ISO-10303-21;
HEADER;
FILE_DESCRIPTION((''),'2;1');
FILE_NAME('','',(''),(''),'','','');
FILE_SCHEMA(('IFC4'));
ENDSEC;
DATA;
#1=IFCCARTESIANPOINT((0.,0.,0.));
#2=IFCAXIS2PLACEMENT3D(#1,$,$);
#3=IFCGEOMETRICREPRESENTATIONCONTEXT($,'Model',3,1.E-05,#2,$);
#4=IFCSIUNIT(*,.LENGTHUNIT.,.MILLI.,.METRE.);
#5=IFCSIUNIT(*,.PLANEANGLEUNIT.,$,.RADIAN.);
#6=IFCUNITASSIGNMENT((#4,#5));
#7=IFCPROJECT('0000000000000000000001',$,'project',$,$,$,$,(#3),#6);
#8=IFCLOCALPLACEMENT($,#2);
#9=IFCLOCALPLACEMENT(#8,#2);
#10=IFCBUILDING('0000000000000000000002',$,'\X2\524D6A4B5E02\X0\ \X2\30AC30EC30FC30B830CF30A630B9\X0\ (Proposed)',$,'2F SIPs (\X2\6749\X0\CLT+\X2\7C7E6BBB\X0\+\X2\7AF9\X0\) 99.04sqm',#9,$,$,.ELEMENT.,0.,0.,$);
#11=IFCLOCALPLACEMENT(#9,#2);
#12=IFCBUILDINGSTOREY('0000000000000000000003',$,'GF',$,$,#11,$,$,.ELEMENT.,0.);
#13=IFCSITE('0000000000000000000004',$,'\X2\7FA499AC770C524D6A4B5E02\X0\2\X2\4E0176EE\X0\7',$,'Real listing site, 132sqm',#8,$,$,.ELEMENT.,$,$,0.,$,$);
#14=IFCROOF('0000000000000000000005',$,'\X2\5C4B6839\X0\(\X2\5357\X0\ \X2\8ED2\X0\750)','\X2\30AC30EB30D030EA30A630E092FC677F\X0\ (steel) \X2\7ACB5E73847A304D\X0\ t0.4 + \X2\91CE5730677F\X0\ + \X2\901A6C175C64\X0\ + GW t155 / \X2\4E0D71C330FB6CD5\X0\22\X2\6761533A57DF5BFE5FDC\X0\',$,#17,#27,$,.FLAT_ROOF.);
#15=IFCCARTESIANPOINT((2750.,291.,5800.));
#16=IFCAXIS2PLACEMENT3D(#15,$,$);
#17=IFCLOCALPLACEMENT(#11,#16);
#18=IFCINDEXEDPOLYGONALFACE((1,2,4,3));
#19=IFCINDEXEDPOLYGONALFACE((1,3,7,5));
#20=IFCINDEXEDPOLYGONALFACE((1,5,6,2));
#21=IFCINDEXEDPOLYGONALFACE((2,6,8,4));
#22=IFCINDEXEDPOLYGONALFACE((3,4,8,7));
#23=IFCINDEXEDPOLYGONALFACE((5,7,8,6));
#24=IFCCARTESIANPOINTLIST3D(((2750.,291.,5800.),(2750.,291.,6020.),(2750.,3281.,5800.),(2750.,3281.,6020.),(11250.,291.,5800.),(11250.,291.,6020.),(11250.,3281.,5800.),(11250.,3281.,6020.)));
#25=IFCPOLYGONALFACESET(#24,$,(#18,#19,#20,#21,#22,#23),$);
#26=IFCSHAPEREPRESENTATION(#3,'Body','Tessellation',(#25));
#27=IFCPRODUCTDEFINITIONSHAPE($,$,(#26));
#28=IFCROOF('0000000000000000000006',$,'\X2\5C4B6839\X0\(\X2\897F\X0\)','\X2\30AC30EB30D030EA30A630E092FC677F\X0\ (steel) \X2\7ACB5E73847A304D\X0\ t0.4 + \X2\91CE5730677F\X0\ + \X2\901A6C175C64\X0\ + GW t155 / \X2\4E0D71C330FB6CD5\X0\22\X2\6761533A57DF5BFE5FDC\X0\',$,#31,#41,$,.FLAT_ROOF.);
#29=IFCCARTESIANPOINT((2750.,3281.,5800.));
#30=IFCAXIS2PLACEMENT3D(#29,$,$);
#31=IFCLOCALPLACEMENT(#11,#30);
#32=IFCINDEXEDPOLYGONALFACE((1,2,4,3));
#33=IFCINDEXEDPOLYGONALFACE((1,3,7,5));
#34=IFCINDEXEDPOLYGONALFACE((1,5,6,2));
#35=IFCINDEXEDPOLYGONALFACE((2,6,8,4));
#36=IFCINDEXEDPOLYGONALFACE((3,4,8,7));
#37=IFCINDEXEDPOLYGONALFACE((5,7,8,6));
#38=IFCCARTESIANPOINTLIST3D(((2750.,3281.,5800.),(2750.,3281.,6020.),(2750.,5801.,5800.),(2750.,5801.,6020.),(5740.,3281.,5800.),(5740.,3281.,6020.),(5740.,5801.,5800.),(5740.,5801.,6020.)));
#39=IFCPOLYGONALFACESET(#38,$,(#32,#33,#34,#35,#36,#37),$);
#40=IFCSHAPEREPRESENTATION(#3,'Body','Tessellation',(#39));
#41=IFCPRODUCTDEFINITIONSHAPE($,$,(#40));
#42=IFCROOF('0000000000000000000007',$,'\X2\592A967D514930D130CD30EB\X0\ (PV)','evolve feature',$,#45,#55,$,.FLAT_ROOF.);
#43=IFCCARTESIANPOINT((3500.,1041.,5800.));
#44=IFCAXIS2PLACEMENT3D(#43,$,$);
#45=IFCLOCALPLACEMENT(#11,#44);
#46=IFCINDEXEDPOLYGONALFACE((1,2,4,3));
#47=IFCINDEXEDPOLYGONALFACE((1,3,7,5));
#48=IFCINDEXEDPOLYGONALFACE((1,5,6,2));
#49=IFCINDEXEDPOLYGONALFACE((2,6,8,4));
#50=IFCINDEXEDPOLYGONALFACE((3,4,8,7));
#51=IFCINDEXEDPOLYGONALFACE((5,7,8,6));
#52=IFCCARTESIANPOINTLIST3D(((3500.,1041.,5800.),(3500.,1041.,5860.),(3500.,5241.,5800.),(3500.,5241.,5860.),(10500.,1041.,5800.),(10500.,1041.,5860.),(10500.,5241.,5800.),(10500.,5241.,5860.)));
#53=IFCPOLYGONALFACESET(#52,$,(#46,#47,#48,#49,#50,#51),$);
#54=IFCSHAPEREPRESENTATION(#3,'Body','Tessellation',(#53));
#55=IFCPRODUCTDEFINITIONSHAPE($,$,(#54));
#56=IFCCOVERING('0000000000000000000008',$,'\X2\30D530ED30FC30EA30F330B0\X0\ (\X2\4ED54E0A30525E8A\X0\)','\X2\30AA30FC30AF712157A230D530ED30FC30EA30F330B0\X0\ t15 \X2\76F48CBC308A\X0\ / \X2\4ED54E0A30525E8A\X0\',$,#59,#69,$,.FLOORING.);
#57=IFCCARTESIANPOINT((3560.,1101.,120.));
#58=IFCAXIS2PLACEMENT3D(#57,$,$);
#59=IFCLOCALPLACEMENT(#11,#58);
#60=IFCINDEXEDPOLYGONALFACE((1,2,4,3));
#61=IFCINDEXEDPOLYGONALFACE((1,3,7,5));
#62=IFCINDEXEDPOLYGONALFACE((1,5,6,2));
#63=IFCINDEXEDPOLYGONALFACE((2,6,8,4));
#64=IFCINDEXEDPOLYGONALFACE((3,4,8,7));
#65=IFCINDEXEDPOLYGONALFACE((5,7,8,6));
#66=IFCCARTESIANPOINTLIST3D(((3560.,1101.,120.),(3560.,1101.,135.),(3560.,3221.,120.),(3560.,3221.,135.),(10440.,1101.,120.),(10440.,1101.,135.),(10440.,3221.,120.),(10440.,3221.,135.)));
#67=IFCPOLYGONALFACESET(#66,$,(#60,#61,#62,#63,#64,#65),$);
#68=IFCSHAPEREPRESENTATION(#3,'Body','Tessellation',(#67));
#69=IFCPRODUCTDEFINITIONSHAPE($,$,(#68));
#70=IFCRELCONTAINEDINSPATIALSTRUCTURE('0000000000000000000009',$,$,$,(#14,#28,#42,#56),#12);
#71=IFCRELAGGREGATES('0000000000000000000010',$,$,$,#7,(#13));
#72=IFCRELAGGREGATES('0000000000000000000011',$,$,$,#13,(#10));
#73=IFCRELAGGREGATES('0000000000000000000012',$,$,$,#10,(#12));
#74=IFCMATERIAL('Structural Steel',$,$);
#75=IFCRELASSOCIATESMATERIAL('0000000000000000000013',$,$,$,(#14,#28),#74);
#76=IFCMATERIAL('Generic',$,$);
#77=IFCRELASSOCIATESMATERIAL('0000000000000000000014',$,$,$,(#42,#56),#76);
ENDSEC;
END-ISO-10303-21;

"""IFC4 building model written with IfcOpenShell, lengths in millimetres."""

from ifc_helpers import new_model, si_unit, frame, frame_2d, origin, place, context, project, spatial, rectangle, extrude, material, element, save


model = new_model("IFC4")

# Units and contexts
model_context = context("Model", 3, precision=1e-05, world=origin())
ifc_project = project(units=[si_unit("LENGTHUNIT", "METRE", prefix="MILLI"), si_unit("PLANEANGLEUNIT", "RADIAN")], contexts=[model_context])

# Site, building, storey
site_placement = place(None, origin())
site = spatial("IfcSite", under=ifc_project, at=site_placement, Name="群馬県前橋市2丁目7", ObjectType="Real listing site, 132sqm", CompositionType="ELEMENT", RefElevation=0.0)
building_placement = place(site_placement, origin())
building = spatial("IfcBuilding", under=site, at=building_placement, Name="前橋市 ガレージハウス (Proposed)", ObjectType="2F SIPs (杉CLT+籾殻+竹) 99.04sqm", CompositionType="ELEMENT", ElevationOfRefHeight=0.0, ElevationOfTerrain=0.0)
storey_placement = place(building_placement, origin())
storey = spatial("IfcBuildingStorey", under=building, at=storey_placement, Name="GF", CompositionType="ELEMENT", Elevation=0.0)

# Shared definitions
ifc_material_1 = material(Name="Generic")

# Roofs
ifc_material_2 = material(Name="Structural Steel")
roof_1_placement = place(storey_placement, frame((2750.0, 291.0, 5800.0)))
element("IfcRoof", 1, at=roof_1_placement, inside=storey, material=ifc_material_2, Name="屋根(南 軒750)", Description="ガルバリウム鋼板 (steel) 立平葺き t0.4 + 野地板 + 通気層 + GW t155 / 不燃・法22条区域対応", PredefinedType="FLAT_ROOF", context=model_context, shape_type="SweptSolid", body=[
    extrude(rectangle(XDim=8500.0, YDim=2990.0, at=frame_2d((4250.0, 1495.0))), frame((2750.0, 291.0, 5800.0)), (0.0, 0.0, 1.0), 220.0),
])
roof_2_placement = place(storey_placement, frame((2750.0, 3281.0, 5800.0)))
element("IfcRoof", 2, at=roof_2_placement, inside=storey, material=ifc_material_2, Name="屋根(西)", Description="ガルバリウム鋼板 (steel) 立平葺き t0.4 + 野地板 + 通気層 + GW t155 / 不燃・法22条区域対応", PredefinedType="FLAT_ROOF", context=model_context, shape_type="SweptSolid", body=[
    extrude(rectangle(XDim=2990.0, YDim=2520.0, at=frame_2d((1495.0, 1260.0))), frame((2750.0, 3281.0, 5800.0)), (0.0, 0.0, 1.0), 220.0),
])
roof_3_placement = place(storey_placement, frame((3500.0, 1041.0, 5800.0)))
element("IfcRoof", 3, at=roof_3_placement, inside=storey, material=ifc_material_1, Name="太陽光パネル (PV)", Description="evolve feature", PredefinedType="FLAT_ROOF", context=model_context, shape_type="SweptSolid", body=[
    extrude(rectangle(XDim=7000.0, YDim=4200.0, at=frame_2d((3500.0, 2100.0))), frame((3500.0, 1041.0, 5800.0)), (0.0, 0.0, 1.0), 60.0),
])

# Covering
covering_placement = place(storey_placement, frame((3560.0, 1101.0, 120.0)))
element("IfcCovering", 4, at=covering_placement, inside=storey, material=ifc_material_1, Name="フローリング (仕上げ床)", Description="オーク無垢フローリング t15 直貼り / 仕上げ床", PredefinedType="FLOORING", context=model_context, shape_type="SweptSolid", body=[
    extrude(rectangle(XDim=6880.0, YDim=2120.0, at=frame_2d((3440.0, 1060.0))), frame((3560.0, 1101.0, 120.0)), (0.0, 0.0, 1.0), 15.0),
])

save(model, "model.ifc")
